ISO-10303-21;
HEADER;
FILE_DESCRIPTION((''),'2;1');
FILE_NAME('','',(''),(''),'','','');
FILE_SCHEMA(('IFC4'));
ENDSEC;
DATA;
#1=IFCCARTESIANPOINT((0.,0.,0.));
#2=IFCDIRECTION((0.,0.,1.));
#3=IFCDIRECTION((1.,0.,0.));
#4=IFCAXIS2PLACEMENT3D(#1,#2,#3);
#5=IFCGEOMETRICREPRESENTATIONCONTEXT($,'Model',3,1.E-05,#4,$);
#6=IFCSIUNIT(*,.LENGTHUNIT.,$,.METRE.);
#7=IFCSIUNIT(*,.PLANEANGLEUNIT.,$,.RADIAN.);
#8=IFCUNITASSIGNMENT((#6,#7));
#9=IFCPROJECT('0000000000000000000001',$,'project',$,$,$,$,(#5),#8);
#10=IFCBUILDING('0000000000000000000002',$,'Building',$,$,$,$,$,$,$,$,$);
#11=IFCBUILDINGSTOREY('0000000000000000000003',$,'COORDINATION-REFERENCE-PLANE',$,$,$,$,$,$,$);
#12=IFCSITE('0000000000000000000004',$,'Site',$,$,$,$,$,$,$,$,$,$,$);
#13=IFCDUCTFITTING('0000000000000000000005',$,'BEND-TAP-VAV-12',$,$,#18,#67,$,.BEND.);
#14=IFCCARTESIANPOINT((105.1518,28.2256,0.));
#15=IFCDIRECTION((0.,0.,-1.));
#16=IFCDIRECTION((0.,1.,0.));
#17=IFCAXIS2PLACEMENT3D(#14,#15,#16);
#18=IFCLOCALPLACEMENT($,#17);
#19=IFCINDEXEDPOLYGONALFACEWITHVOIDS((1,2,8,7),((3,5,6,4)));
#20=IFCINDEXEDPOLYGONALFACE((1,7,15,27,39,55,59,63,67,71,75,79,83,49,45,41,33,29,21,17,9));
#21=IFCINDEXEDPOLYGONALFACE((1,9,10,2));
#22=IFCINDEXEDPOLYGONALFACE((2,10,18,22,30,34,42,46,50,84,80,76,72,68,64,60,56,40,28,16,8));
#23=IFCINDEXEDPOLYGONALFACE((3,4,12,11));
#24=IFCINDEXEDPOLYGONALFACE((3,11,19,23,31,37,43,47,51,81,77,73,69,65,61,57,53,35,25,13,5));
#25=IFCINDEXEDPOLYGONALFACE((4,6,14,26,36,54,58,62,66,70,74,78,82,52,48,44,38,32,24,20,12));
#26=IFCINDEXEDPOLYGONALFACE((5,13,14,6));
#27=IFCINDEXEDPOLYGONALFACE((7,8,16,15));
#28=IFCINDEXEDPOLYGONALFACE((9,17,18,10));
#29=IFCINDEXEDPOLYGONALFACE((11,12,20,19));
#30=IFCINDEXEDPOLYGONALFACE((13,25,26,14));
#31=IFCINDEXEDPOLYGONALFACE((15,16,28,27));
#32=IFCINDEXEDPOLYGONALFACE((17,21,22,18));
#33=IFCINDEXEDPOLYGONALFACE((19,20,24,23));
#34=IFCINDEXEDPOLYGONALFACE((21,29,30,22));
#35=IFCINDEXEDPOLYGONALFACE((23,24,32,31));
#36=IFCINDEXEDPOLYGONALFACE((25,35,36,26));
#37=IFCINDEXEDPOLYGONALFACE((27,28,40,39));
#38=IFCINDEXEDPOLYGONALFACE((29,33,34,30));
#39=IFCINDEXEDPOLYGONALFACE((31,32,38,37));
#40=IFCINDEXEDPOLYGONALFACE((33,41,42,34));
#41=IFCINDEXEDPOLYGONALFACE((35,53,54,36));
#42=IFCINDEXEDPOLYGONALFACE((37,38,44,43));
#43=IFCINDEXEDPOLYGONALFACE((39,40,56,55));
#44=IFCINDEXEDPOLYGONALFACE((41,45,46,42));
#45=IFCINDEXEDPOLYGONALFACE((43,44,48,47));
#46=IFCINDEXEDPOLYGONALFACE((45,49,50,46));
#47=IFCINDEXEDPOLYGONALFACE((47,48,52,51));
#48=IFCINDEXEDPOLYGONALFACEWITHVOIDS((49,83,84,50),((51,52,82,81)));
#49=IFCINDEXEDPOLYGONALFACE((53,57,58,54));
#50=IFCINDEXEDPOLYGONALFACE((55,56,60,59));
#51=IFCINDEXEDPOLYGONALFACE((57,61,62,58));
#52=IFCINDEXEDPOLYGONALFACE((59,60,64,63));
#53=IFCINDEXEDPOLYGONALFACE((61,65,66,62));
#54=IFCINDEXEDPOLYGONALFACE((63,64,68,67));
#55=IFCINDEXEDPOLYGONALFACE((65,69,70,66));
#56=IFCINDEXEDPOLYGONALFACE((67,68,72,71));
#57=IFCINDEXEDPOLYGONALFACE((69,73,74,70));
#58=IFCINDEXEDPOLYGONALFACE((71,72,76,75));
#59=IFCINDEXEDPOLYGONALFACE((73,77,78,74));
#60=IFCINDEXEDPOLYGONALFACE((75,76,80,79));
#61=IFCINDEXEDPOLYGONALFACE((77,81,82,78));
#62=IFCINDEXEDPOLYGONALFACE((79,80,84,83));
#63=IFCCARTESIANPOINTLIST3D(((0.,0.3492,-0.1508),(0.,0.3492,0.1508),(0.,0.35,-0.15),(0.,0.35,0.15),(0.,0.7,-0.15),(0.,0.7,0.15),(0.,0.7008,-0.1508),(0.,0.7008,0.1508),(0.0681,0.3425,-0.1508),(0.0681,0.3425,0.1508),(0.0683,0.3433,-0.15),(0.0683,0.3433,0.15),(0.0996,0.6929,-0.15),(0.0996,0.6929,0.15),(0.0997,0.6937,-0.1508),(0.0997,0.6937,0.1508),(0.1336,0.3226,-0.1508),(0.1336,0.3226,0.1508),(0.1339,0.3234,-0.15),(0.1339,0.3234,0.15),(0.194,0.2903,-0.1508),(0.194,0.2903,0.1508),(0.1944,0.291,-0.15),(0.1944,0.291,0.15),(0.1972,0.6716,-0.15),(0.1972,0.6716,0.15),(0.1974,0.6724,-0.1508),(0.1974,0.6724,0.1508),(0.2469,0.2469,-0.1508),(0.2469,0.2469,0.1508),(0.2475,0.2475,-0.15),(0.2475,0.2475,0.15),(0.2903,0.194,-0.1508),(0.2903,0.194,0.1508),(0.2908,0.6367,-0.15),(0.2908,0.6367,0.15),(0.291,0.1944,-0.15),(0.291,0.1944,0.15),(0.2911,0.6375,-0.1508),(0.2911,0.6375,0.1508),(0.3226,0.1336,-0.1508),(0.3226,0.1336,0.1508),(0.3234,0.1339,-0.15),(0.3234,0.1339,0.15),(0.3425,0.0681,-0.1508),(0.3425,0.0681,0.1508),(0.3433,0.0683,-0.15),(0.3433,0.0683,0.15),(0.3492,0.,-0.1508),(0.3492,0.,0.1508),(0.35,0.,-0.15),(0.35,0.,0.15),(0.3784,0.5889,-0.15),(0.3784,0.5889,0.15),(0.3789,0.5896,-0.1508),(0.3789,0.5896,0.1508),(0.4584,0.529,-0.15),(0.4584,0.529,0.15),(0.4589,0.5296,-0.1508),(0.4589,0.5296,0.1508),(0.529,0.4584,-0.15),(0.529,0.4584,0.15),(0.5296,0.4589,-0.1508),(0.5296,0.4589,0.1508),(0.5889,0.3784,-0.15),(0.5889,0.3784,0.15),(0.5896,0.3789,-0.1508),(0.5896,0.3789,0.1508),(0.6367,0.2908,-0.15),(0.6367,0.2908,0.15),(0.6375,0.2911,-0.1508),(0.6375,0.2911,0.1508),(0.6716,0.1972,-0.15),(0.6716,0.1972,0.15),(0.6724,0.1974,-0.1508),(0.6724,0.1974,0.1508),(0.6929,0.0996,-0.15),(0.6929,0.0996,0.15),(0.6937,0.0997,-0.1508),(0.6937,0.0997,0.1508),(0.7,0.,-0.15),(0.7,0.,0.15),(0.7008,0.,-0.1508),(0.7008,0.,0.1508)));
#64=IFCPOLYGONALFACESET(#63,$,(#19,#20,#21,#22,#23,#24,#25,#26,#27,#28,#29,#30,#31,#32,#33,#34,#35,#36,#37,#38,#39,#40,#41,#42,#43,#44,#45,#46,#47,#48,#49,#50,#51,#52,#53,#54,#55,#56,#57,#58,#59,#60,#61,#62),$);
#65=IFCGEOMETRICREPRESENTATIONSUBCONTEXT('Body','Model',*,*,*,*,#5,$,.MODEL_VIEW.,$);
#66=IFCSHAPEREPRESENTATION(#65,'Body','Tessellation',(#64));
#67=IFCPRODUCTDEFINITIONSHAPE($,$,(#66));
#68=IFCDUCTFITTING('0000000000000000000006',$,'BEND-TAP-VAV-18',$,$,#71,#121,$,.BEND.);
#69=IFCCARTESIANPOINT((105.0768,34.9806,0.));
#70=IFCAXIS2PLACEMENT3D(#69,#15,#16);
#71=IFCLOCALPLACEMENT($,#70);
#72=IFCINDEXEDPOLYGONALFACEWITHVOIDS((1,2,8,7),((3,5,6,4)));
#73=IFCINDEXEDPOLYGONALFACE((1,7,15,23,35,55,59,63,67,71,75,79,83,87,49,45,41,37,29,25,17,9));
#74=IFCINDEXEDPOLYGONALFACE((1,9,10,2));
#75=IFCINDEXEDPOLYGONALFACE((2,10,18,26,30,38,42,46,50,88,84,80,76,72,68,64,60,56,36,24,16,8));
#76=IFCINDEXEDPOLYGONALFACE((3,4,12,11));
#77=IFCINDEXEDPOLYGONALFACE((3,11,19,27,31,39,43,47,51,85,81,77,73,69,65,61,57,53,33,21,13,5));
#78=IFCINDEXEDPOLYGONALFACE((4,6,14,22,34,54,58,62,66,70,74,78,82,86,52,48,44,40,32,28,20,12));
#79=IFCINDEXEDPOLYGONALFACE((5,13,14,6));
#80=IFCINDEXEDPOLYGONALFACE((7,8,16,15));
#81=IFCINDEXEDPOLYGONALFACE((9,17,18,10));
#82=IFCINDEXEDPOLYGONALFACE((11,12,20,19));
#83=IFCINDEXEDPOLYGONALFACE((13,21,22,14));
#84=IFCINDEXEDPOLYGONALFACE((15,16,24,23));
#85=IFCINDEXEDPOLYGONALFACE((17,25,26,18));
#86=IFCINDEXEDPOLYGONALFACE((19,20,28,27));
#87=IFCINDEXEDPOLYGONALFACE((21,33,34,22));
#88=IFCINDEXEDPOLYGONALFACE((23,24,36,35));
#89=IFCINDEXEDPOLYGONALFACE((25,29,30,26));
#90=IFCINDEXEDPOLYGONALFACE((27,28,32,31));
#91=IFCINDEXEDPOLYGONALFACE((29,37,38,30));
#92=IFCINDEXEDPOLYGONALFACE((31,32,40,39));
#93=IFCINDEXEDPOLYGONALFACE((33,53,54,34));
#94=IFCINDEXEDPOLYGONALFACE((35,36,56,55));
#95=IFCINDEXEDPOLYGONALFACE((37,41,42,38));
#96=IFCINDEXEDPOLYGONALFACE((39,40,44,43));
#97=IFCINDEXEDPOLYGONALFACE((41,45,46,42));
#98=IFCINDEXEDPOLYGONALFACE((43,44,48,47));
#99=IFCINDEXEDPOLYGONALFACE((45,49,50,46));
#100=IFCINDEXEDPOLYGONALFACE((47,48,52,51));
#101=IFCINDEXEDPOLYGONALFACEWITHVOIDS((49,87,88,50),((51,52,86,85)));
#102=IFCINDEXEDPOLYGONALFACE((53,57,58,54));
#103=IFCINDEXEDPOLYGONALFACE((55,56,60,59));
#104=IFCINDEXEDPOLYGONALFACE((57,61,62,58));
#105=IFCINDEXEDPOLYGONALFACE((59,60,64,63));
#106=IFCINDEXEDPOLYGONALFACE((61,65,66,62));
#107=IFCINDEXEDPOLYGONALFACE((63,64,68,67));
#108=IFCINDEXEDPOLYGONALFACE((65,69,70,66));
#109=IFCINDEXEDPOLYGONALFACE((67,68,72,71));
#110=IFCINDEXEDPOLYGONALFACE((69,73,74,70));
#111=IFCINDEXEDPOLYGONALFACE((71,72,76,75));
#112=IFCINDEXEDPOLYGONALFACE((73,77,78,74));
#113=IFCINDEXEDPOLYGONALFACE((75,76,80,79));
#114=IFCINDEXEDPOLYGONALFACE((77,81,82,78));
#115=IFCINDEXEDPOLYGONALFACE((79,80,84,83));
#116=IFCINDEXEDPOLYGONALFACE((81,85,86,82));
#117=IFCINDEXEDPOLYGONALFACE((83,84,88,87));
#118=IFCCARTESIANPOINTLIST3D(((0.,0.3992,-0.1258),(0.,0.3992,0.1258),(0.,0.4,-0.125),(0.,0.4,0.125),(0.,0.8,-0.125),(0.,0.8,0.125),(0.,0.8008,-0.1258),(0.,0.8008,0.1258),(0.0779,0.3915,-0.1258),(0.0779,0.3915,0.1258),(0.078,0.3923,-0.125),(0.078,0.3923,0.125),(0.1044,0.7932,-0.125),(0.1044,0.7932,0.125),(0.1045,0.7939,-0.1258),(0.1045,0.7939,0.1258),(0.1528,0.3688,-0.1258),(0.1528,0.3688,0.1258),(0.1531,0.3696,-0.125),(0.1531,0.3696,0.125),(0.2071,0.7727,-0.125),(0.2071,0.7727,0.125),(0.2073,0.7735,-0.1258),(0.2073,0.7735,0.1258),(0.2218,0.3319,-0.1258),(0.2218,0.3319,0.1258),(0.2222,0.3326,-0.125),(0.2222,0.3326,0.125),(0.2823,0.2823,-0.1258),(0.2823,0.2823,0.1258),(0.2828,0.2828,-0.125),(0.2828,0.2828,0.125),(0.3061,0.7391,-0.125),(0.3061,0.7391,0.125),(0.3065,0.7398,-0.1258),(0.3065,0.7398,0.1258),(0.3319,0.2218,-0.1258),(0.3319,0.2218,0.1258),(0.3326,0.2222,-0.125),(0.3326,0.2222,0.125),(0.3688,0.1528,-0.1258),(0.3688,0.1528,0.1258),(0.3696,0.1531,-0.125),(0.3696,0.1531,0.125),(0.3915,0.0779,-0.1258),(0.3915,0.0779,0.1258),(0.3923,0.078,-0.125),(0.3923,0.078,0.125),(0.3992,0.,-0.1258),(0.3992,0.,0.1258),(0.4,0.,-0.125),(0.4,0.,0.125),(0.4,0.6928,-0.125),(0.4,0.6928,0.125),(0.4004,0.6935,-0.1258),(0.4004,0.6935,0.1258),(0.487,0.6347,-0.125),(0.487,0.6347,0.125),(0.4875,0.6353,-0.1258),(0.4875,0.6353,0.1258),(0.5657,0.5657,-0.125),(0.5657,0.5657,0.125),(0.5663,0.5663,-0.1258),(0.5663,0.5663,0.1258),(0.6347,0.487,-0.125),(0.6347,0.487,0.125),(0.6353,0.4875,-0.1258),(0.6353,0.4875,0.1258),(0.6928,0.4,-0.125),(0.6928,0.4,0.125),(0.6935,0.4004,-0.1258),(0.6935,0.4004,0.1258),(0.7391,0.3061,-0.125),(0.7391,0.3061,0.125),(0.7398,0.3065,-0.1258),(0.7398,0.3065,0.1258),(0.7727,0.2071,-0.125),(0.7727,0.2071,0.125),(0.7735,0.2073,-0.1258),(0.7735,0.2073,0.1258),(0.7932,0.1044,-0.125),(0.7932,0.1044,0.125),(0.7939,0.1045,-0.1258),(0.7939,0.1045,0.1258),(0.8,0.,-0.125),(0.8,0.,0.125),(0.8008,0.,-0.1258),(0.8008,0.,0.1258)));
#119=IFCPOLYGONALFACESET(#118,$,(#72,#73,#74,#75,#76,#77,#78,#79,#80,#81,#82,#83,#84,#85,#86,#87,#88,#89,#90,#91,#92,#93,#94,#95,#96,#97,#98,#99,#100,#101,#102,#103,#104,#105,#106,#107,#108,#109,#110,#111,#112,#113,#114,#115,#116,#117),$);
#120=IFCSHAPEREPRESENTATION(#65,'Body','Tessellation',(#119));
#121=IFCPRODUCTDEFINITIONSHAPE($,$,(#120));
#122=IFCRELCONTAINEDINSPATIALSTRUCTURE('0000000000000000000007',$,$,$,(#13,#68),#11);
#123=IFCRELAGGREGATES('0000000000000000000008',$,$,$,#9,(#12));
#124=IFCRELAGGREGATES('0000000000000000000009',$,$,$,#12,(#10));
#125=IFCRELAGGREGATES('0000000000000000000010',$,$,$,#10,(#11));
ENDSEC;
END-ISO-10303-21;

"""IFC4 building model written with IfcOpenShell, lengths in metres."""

from ifc_helpers import new_model, entity, si_unit, frame, origin_with_axes, place, context, subcontext, project, spatial, element, save


model = new_model("IFC4")

# Units and contexts
model_context = context("Model", 3, precision=1e-05, world=origin_with_axes())
body_context_1 = subcontext(model_context, "Body", "Model", "MODEL_VIEW")
ifc_project = project(units=[si_unit("LENGTHUNIT", "METRE"), si_unit("PLANEANGLEUNIT", "RADIAN")], contexts=[model_context])

# Site, building, storey
site = spatial("IfcSite", under=ifc_project, Name="Site")
building = spatial("IfcBuilding", under=site, Name="Building")
storey = spatial("IfcBuildingStorey", under=building, Name="COORDINATION-REFERENCE-PLANE")

# Duct fittings
duct_fitting_1_placement = place(None, frame((105.1518, 28.2256, 0.0), z_axis=(0.0, 0.0, -1.0), x_axis=(0.0, 1.0, 0.0)))
cartesian_point_1 = entity("IfcCartesianPoint", [0.0, 0.0, 0.0])
element("IfcDuctFitting", 1, at=duct_fitting_1_placement, inside=storey, Name="BEND-TAP-VAV-12", PredefinedType="BEND", context=body_context_1, shape_type="SweptSolid", body=[
    entity("IfcRevolvedAreaSolid", entity("IfcRectangleHollowProfileDef", "AREA", None, entity("IfcAxis2Placement2D", entity("IfcCartesianPoint", [0.525, 0.0])), 0.3516, 0.3016, 0.0008), entity("IfcAxis2Placement3D", cartesian_point_1, entity("IfcDirection", [0.0, -1.0, 0.0]), entity("IfcDirection", [1.0, 0.0, 0.0])), entity("IfcAxis1Placement", cartesian_point_1, entity("IfcDirection", [0.0, 1.0, 0.0])), 1.570796),
])
duct_fitting_2_placement = place(None, frame((105.0768, 34.9806, 0.0), z_axis=(0.0, 0.0, -1.0), x_axis=(0.0, 1.0, 0.0)))
cartesian_point_2 = entity("IfcCartesianPoint", [0.0, 0.0, 0.0])
element("IfcDuctFitting", 2, at=duct_fitting_2_placement, inside=storey, Name="BEND-TAP-VAV-18", PredefinedType="BEND", context=body_context_1, shape_type="SweptSolid", body=[
    entity("IfcRevolvedAreaSolid", entity("IfcRectangleHollowProfileDef", "AREA", None, entity("IfcAxis2Placement2D", entity("IfcCartesianPoint", [0.6, 0.0])), 0.4016, 0.2516, 0.0008), entity("IfcAxis2Placement3D", cartesian_point_2, entity("IfcDirection", [0.0, -1.0, 0.0]), entity("IfcDirection", [1.0, 0.0, 0.0])), entity("IfcAxis1Placement", cartesian_point_2, entity("IfcDirection", [0.0, 1.0, 0.0])), 1.570796),
])

save(model, "model.ifc")
